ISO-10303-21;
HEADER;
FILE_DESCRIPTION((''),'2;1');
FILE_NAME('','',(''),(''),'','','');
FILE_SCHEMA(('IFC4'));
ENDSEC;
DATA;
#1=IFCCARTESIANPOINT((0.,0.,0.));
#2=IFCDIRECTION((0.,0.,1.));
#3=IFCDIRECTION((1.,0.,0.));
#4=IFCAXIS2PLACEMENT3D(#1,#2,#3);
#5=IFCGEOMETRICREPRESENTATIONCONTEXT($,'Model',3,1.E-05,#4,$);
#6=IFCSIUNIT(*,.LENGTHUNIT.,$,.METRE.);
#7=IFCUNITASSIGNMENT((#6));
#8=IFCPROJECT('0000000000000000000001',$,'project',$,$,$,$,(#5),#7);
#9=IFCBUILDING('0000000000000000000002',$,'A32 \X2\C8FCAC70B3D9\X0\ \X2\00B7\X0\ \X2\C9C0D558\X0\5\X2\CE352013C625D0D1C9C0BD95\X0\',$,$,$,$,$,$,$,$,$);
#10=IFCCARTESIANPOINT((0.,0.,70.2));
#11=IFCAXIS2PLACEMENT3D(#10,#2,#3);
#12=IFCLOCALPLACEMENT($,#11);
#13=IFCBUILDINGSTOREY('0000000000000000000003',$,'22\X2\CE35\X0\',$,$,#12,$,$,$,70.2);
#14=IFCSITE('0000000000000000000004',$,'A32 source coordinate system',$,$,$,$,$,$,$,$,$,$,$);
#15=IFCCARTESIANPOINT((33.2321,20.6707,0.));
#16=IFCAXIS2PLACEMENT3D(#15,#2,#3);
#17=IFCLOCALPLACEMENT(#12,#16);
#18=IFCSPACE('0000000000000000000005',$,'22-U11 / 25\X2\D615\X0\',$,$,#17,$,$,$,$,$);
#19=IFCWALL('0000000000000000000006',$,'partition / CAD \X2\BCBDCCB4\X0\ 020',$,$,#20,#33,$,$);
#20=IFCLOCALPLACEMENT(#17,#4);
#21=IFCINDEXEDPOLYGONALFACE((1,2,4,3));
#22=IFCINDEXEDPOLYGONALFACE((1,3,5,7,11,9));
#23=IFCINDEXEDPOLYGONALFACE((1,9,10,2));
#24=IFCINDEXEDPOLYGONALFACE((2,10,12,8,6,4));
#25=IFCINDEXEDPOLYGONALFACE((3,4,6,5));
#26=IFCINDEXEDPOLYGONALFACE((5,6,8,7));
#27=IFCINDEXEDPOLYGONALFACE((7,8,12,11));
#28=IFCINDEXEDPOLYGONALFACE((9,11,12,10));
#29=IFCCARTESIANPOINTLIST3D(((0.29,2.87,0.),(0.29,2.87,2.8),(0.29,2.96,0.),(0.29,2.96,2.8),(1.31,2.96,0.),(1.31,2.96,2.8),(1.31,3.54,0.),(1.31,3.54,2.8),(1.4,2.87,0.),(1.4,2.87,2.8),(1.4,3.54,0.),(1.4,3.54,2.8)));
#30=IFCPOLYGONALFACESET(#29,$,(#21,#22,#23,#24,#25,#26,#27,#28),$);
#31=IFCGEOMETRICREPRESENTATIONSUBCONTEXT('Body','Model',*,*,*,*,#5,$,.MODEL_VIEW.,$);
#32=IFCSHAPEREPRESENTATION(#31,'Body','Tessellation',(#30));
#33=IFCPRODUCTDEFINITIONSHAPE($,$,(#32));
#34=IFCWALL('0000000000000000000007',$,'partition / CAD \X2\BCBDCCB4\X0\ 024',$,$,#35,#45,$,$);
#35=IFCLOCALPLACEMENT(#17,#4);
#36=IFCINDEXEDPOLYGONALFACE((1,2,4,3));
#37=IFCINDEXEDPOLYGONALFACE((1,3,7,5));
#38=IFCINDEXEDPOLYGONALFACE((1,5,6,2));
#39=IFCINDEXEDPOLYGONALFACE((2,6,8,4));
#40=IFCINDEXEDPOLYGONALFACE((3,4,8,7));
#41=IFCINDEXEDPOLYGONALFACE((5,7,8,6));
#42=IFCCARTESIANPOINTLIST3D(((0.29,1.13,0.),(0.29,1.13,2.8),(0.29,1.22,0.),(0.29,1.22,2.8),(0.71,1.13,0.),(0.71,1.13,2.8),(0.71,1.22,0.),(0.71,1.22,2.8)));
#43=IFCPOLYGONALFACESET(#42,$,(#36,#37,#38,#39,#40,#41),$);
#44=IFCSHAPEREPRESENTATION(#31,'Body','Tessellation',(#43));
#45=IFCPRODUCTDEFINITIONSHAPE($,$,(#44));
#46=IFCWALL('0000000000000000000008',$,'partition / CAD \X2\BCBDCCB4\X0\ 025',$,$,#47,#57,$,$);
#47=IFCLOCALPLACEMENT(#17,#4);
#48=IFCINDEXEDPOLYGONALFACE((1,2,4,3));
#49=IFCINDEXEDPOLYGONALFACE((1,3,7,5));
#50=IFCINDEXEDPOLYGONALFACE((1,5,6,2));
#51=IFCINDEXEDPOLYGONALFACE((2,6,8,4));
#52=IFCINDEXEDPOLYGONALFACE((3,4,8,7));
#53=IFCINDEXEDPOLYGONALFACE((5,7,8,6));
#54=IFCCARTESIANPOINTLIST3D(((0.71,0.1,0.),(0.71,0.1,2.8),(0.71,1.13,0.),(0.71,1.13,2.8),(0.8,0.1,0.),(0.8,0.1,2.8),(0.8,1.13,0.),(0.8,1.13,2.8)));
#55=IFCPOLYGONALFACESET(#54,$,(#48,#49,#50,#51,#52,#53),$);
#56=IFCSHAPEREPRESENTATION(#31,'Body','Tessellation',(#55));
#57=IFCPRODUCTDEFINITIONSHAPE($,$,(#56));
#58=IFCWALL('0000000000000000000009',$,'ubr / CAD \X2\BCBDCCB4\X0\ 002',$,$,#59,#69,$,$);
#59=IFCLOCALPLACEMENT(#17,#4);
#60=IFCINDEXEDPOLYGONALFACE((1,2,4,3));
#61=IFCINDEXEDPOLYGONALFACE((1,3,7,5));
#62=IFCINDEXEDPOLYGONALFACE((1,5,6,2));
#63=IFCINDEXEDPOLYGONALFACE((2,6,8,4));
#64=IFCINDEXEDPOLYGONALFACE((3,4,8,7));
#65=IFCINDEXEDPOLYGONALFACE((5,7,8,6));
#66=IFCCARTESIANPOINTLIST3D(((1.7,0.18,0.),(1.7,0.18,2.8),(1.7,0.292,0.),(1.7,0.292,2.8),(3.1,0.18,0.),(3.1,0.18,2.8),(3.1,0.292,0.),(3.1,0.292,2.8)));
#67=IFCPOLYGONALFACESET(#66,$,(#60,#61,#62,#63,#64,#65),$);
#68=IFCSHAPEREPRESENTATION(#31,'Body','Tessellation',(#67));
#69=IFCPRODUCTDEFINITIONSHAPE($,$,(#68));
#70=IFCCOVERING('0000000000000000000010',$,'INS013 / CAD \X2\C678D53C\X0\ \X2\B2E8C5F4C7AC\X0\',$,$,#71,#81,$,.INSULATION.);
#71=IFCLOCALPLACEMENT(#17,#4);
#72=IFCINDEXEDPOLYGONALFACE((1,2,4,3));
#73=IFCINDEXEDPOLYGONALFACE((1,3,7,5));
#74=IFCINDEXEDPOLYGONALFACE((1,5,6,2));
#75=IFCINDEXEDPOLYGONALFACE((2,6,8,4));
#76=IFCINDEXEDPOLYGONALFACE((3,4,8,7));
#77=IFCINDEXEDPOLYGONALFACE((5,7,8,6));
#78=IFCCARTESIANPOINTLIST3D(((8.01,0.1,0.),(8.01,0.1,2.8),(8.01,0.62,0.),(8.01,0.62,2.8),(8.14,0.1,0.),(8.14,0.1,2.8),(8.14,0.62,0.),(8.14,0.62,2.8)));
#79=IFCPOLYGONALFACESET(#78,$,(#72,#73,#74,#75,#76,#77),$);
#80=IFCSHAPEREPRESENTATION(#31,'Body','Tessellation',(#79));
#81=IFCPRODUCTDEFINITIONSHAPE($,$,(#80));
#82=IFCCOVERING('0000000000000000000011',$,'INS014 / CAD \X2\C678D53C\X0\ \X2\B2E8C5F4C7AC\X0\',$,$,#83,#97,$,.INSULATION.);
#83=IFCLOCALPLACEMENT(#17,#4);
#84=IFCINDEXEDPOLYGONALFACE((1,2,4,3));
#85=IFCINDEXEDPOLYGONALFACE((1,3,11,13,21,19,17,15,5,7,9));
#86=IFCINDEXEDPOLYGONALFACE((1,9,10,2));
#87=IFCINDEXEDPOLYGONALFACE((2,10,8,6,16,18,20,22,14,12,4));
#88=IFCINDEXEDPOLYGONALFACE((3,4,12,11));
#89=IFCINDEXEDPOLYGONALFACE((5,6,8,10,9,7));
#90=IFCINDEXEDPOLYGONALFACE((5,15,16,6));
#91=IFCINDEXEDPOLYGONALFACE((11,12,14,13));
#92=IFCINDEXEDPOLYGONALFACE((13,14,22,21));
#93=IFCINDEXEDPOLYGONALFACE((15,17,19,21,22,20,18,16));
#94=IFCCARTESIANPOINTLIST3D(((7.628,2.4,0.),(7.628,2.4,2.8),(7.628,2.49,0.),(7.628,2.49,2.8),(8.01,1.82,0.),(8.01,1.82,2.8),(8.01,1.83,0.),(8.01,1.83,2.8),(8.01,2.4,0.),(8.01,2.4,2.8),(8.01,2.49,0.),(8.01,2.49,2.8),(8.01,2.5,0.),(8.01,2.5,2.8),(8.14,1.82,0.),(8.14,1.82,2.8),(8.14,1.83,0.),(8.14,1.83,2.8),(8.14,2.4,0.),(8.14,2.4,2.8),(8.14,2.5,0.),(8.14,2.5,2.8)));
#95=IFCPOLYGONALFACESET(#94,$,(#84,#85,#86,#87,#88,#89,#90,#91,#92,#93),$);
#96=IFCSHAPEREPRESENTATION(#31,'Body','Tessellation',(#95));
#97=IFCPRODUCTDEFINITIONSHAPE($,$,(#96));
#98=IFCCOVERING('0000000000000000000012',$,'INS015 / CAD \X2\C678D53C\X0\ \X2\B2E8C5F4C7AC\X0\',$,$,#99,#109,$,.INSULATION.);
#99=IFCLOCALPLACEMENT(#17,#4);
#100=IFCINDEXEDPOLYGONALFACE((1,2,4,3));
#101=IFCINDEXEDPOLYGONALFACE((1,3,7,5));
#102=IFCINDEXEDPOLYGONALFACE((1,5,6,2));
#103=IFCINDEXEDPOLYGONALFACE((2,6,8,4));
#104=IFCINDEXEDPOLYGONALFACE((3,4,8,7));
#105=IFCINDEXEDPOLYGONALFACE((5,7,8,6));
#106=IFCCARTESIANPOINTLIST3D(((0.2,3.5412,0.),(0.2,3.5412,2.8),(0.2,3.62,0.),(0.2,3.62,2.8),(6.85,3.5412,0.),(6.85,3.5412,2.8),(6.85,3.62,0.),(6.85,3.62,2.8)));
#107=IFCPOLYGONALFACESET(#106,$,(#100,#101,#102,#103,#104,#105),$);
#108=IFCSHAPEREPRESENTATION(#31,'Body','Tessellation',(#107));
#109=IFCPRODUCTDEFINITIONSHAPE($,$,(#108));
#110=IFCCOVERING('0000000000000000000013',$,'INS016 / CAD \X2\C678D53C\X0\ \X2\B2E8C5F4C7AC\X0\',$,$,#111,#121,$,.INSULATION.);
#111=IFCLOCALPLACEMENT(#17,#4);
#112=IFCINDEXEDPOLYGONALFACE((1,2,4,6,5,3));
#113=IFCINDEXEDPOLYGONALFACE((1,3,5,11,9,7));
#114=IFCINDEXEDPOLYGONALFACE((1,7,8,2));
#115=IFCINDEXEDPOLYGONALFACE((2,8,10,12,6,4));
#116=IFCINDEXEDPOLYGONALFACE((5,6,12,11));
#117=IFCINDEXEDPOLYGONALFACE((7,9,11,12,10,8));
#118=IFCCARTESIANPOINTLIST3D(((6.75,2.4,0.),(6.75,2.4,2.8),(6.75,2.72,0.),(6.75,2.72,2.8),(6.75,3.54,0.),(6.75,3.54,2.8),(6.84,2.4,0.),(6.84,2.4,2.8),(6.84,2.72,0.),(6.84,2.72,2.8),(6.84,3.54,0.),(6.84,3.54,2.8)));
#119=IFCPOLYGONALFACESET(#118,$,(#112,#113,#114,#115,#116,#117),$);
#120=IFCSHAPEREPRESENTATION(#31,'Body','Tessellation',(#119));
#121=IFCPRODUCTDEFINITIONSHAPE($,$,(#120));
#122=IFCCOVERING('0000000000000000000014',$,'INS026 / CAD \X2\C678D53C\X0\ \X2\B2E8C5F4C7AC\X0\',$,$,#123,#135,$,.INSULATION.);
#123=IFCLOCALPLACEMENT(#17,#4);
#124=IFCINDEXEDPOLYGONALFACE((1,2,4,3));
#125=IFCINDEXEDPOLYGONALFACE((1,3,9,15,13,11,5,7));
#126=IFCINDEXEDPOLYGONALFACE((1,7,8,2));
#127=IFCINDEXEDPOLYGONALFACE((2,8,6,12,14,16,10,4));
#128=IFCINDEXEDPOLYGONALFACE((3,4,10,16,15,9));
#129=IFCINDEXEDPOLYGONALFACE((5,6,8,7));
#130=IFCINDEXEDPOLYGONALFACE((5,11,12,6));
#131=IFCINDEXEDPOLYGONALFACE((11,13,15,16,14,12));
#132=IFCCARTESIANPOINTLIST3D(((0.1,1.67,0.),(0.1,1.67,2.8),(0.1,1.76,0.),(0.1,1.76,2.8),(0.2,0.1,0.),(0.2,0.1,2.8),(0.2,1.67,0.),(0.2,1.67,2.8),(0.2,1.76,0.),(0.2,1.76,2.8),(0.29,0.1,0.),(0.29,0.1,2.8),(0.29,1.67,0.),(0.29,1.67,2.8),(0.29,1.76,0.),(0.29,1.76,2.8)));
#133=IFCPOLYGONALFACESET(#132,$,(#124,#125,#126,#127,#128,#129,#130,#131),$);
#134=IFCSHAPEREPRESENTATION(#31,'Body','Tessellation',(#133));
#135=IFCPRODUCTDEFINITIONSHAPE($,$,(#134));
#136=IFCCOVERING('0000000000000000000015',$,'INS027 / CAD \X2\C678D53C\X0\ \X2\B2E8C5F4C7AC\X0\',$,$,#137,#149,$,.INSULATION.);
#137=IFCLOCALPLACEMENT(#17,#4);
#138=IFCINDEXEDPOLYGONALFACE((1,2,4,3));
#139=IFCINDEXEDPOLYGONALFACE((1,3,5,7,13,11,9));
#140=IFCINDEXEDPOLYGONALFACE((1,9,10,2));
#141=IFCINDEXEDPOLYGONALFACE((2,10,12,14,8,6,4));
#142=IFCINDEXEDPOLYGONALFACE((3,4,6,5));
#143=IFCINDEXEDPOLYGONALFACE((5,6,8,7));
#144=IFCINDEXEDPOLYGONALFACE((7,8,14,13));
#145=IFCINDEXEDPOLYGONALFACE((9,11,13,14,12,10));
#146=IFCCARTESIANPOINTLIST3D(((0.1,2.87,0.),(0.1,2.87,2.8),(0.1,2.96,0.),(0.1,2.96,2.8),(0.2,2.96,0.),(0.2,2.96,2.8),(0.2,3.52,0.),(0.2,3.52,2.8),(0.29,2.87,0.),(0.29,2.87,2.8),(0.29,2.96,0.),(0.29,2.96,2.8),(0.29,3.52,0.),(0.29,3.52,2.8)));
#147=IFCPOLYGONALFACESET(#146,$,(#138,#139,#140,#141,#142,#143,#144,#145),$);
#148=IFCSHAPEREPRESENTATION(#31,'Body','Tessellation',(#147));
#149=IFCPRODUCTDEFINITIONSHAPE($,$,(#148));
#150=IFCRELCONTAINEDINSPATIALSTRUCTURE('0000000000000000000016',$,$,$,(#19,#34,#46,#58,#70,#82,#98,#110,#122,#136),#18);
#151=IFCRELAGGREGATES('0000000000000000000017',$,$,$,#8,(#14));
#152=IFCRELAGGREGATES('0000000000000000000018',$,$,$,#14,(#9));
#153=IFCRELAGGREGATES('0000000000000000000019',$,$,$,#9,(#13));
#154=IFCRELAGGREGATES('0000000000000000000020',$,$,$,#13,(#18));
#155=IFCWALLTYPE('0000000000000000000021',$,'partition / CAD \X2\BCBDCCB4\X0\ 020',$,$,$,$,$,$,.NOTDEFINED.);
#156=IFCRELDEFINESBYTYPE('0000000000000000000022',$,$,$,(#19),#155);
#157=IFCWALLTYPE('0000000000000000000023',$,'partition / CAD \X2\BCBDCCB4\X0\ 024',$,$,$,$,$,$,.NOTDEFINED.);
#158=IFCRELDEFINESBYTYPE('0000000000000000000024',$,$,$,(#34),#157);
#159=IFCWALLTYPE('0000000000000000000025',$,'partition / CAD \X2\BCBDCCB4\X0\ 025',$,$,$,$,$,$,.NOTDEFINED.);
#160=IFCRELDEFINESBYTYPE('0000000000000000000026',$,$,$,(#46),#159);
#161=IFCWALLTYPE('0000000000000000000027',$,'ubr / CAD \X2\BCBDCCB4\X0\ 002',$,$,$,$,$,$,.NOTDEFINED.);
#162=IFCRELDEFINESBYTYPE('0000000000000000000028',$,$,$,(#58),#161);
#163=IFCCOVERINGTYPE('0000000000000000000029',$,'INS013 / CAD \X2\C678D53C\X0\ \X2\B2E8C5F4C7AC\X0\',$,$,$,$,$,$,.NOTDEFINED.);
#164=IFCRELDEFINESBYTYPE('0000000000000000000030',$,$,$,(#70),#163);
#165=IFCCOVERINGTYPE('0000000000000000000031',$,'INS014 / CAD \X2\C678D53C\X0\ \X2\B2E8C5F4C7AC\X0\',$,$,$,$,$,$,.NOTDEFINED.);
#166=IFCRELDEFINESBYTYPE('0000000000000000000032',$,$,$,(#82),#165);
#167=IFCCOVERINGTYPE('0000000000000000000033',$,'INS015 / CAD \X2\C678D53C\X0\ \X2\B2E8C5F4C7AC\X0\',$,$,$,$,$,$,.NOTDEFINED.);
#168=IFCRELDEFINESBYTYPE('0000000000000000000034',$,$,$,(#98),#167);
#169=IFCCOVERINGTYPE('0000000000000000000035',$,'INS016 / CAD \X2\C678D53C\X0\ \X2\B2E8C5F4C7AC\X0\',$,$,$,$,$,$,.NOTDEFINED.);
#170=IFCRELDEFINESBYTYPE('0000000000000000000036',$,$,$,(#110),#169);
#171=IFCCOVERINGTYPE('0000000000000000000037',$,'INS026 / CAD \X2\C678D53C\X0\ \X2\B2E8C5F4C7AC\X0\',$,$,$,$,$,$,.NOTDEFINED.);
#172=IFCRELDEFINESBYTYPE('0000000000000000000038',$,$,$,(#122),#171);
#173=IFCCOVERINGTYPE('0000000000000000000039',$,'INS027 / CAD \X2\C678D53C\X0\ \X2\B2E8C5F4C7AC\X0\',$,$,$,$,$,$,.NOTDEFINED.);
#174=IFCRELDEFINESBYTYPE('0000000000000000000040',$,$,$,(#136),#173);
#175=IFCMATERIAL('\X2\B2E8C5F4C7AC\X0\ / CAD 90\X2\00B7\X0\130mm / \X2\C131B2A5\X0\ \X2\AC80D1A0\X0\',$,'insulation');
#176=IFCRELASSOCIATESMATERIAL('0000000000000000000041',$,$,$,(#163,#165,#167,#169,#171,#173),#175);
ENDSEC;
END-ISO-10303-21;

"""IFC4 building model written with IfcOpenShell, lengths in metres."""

from ifc_helpers import new_model, si_unit, frame, origin, origin_with_axes, place, context, subcontext, project, spatial, polyline, outline, extrude, source, transform, mapped, material, type_object, type_shapes, element, save


model = new_model("IFC4")

# Units and contexts
model_context = context("Model", 3, precision=1e-05, world=origin_with_axes())
body_context = subcontext(model_context, "Body", "Model", "MODEL_VIEW")
ifc_project = project(units=[si_unit("LENGTHUNIT", "METRE")], contexts=[model_context])

# Site, building, storey, space
storey_placement = place(None, frame((0.0, 0.0, 70.2), z_axis=(0.0, 0.0, 1.0), x_axis=(1.0, 0.0, 0.0)))
space_placement = place(storey_placement, frame((33.2321, 20.6707, 0.0), z_axis=(0.0, 0.0, 1.0), x_axis=(1.0, 0.0, 0.0)))
site = spatial("IfcSite", under=ifc_project, Name="A32 source coordinate system")
building = spatial("IfcBuilding", under=site, Name="A32 주거동 · 지하5층–옥탑지붕")
storey = spatial("IfcBuildingStorey", under=building, at=storey_placement, Name="22층", Elevation=70.2)
space = spatial("IfcSpace", under=storey, at=space_placement, Name="22-U11 / 25형")

# Walls
wall_type_1 = type_object("IfcWallType", Name="partition / CAD 벽체 020", PredefinedType="NOTDEFINED")
shared_shape_1 = source(origin(), body_context, "Body", "SweptSolid", [
    extrude(outline(polyline([(0.29, 2.87), (0.29, 2.96), (1.31, 2.96), (1.31, 3.54), (1.4, 3.54), (1.4, 2.87), (0.29, 2.87)])), origin(), (0.0, 0.0, 1.0), 2.8),
])
type_shapes(wall_type_1, [shared_shape_1])
wall_1_placement = place(space_placement, origin_with_axes())
element("IfcWall", 1, at=wall_1_placement, inside=space, type_object=wall_type_1, Name="partition / CAD 벽체 020", context=body_context, shape_type="MappedRepresentation", body=[
    mapped(shared_shape_1, transform((0.0, 0.0, 0.0), scale=1.0)),
])
wall_type_2 = type_object("IfcWallType", Name="partition / CAD 벽체 024", PredefinedType="NOTDEFINED")
shared_shape_2 = source(origin(), body_context, "Body", "SweptSolid", [
    extrude(outline(polyline([(0.71, 1.13), (0.29, 1.13), (0.29, 1.22), (0.71, 1.22), (0.71, 1.13)])), origin(), (0.0, 0.0, 1.0), 2.8),
])
type_shapes(wall_type_2, [shared_shape_2])
wall_2_placement = place(space_placement, origin_with_axes())
element("IfcWall", 2, at=wall_2_placement, inside=space, type_object=wall_type_2, Name="partition / CAD 벽체 024", context=body_context, shape_type="MappedRepresentation", body=[
    mapped(shared_shape_2, transform((0.0, 0.0, 0.0), scale=1.0)),
])
wall_type_3 = type_object("IfcWallType", Name="partition / CAD 벽체 025", PredefinedType="NOTDEFINED")
shared_shape_3 = source(origin(), body_context, "Body", "SweptSolid", [
    extrude(outline(polyline([(0.71, 1.13), (0.8, 1.13), (0.8, 0.1), (0.71, 0.1), (0.71, 1.13)])), origin(), (0.0, 0.0, 1.0), 2.8),
])
type_shapes(wall_type_3, [shared_shape_3])
wall_3_placement = place(space_placement, origin_with_axes())
element("IfcWall", 3, at=wall_3_placement, inside=space, type_object=wall_type_3, Name="partition / CAD 벽체 025", context=body_context, shape_type="MappedRepresentation", body=[
    mapped(shared_shape_3, transform((0.0, 0.0, 0.0), scale=1.0)),
])
wall_type_4 = type_object("IfcWallType", Name="ubr / CAD 벽체 002", PredefinedType="NOTDEFINED")
shared_shape_4 = source(origin(), body_context, "Body", "SweptSolid", [
    extrude(outline(polyline([(3.1, 0.292), (3.1, 0.18), (1.7, 0.18), (1.7, 0.292), (3.1, 0.292)])), origin(), (0.0, 0.0, 1.0), 2.8),
])
type_shapes(wall_type_4, [shared_shape_4])
wall_4_placement = place(space_placement, origin_with_axes())
element("IfcWall", 4, at=wall_4_placement, inside=space, type_object=wall_type_4, Name="ubr / CAD 벽체 002", context=body_context, shape_type="MappedRepresentation", body=[
    mapped(shared_shape_4, transform((0.0, 0.0, 0.0), scale=1.0)),
])

# Coverings
ifc_material = material(Name="단열재 / CAD 90·130mm / 성능 검토", Category="insulation")
covering_type_1 = type_object("IfcCoveringType", Name="INS013 / CAD 외피 단열재", PredefinedType="NOTDEFINED", material=ifc_material)
shared_shape_5 = source(origin(), body_context, "Body", "SweptSolid", [
    extrude(outline(polyline([(8.14, 0.1), (8.01, 0.1), (8.01, 0.62), (8.14, 0.62), (8.14, 0.1)])), origin(), (0.0, 0.0, 1.0), 2.8),
])
type_shapes(covering_type_1, [shared_shape_5])
covering_1_placement = place(space_placement, origin_with_axes())
element("IfcCovering", 5, at=covering_1_placement, inside=space, type_object=covering_type_1, Name="INS013 / CAD 외피 단열재", PredefinedType="INSULATION", context=body_context, shape_type="MappedRepresentation", body=[
    mapped(shared_shape_5, transform((0.0, 0.0, 0.0), scale=1.0)),
])
covering_type_2 = type_object("IfcCoveringType", Name="INS014 / CAD 외피 단열재", PredefinedType="NOTDEFINED", material=ifc_material)
shared_shape_6 = source(origin(), body_context, "Body", "SweptSolid", [
    extrude(outline(polyline([(8.14, 2.5), (8.14, 2.4), (8.14, 1.83), (8.14, 1.82), (8.01, 1.82), (8.01, 1.83), (8.01, 2.4), (7.628, 2.4), (7.628, 2.49), (8.01, 2.49), (8.01, 2.5), (8.14, 2.5)])), origin(), (0.0, 0.0, 1.0), 2.8),
])
type_shapes(covering_type_2, [shared_shape_6])
covering_2_placement = place(space_placement, origin_with_axes())
element("IfcCovering", 6, at=covering_2_placement, inside=space, type_object=covering_type_2, Name="INS014 / CAD 외피 단열재", PredefinedType="INSULATION", context=body_context, shape_type="MappedRepresentation", body=[
    mapped(shared_shape_6, transform((0.0, 0.0, 0.0), scale=1.0)),
])
covering_type_3 = type_object("IfcCoveringType", Name="INS015 / CAD 외피 단열재", PredefinedType="NOTDEFINED", material=ifc_material)
shared_shape_7 = source(origin(), body_context, "Body", "SweptSolid", [
    extrude(outline(polyline([(0.2, 3.5412), (0.2, 3.62), (6.85, 3.62), (6.85, 3.5412), (0.2, 3.5412)])), origin(), (0.0, 0.0, 1.0), 2.8),
])
type_shapes(covering_type_3, [shared_shape_7])
covering_3_placement = place(space_placement, origin_with_axes())
element("IfcCovering", 7, at=covering_3_placement, inside=space, type_object=covering_type_3, Name="INS015 / CAD 외피 단열재", PredefinedType="INSULATION", context=body_context, shape_type="MappedRepresentation", body=[
    mapped(shared_shape_7, transform((0.0, 0.0, 0.0), scale=1.0)),
])
covering_type_4 = type_object("IfcCoveringType", Name="INS016 / CAD 외피 단열재", PredefinedType="NOTDEFINED", material=ifc_material)
shared_shape_8 = source(origin(), body_context, "Body", "SweptSolid", [
    extrude(outline(polyline([(6.84, 2.72), (6.84, 2.4), (6.75, 2.4), (6.75, 2.72), (6.75, 3.54), (6.84, 3.54), (6.84, 2.72)])), origin(), (0.0, 0.0, 1.0), 2.8),
])
type_shapes(covering_type_4, [shared_shape_8])
covering_4_placement = place(space_placement, origin_with_axes())
element("IfcCovering", 8, at=covering_4_placement, inside=space, type_object=covering_type_4, Name="INS016 / CAD 외피 단열재", PredefinedType="INSULATION", context=body_context, shape_type="MappedRepresentation", body=[
    mapped(shared_shape_8, transform((0.0, 0.0, 0.0), scale=1.0)),
])
covering_type_5 = type_object("IfcCoveringType", Name="INS026 / CAD 외피 단열재", PredefinedType="NOTDEFINED", material=ifc_material)
shared_shape_9 = source(origin(), body_context, "Body", "SweptSolid", [
    extrude(outline(polyline([(0.2, 1.76), (0.29, 1.76), (0.29, 1.67), (0.29, 0.1), (0.2, 0.1), (0.2, 1.67), (0.1, 1.67), (0.1, 1.76), (0.2, 1.76)])), origin(), (0.0, 0.0, 1.0), 2.8),
])
type_shapes(covering_type_5, [shared_shape_9])
covering_5_placement = place(space_placement, origin_with_axes())
element("IfcCovering", 9, at=covering_5_placement, inside=space, type_object=covering_type_5, Name="INS026 / CAD 외피 단열재", PredefinedType="INSULATION", context=body_context, shape_type="MappedRepresentation", body=[
    mapped(shared_shape_9, transform((0.0, 0.0, 0.0), scale=1.0)),
])
covering_type_6 = type_object("IfcCoveringType", Name="INS027 / CAD 외피 단열재", PredefinedType="NOTDEFINED", material=ifc_material)
shared_shape_10 = source(origin(), body_context, "Body", "SweptSolid", [
    extrude(outline(polyline([(0.2, 3.52), (0.29, 3.52), (0.29, 2.96), (0.29, 2.87), (0.1, 2.87), (0.1, 2.96), (0.2, 2.96), (0.2, 3.52)])), origin(), (0.0, 0.0, 1.0), 2.8),
])
type_shapes(covering_type_6, [shared_shape_10])
covering_6_placement = place(space_placement, origin_with_axes())
element("IfcCovering", 10, at=covering_6_placement, inside=space, type_object=covering_type_6, Name="INS027 / CAD 외피 단열재", PredefinedType="INSULATION", context=body_context, shape_type="MappedRepresentation", body=[
    mapped(shared_shape_10, transform((0.0, 0.0, 0.0), scale=1.0)),
])

save(model, "model.ifc")
